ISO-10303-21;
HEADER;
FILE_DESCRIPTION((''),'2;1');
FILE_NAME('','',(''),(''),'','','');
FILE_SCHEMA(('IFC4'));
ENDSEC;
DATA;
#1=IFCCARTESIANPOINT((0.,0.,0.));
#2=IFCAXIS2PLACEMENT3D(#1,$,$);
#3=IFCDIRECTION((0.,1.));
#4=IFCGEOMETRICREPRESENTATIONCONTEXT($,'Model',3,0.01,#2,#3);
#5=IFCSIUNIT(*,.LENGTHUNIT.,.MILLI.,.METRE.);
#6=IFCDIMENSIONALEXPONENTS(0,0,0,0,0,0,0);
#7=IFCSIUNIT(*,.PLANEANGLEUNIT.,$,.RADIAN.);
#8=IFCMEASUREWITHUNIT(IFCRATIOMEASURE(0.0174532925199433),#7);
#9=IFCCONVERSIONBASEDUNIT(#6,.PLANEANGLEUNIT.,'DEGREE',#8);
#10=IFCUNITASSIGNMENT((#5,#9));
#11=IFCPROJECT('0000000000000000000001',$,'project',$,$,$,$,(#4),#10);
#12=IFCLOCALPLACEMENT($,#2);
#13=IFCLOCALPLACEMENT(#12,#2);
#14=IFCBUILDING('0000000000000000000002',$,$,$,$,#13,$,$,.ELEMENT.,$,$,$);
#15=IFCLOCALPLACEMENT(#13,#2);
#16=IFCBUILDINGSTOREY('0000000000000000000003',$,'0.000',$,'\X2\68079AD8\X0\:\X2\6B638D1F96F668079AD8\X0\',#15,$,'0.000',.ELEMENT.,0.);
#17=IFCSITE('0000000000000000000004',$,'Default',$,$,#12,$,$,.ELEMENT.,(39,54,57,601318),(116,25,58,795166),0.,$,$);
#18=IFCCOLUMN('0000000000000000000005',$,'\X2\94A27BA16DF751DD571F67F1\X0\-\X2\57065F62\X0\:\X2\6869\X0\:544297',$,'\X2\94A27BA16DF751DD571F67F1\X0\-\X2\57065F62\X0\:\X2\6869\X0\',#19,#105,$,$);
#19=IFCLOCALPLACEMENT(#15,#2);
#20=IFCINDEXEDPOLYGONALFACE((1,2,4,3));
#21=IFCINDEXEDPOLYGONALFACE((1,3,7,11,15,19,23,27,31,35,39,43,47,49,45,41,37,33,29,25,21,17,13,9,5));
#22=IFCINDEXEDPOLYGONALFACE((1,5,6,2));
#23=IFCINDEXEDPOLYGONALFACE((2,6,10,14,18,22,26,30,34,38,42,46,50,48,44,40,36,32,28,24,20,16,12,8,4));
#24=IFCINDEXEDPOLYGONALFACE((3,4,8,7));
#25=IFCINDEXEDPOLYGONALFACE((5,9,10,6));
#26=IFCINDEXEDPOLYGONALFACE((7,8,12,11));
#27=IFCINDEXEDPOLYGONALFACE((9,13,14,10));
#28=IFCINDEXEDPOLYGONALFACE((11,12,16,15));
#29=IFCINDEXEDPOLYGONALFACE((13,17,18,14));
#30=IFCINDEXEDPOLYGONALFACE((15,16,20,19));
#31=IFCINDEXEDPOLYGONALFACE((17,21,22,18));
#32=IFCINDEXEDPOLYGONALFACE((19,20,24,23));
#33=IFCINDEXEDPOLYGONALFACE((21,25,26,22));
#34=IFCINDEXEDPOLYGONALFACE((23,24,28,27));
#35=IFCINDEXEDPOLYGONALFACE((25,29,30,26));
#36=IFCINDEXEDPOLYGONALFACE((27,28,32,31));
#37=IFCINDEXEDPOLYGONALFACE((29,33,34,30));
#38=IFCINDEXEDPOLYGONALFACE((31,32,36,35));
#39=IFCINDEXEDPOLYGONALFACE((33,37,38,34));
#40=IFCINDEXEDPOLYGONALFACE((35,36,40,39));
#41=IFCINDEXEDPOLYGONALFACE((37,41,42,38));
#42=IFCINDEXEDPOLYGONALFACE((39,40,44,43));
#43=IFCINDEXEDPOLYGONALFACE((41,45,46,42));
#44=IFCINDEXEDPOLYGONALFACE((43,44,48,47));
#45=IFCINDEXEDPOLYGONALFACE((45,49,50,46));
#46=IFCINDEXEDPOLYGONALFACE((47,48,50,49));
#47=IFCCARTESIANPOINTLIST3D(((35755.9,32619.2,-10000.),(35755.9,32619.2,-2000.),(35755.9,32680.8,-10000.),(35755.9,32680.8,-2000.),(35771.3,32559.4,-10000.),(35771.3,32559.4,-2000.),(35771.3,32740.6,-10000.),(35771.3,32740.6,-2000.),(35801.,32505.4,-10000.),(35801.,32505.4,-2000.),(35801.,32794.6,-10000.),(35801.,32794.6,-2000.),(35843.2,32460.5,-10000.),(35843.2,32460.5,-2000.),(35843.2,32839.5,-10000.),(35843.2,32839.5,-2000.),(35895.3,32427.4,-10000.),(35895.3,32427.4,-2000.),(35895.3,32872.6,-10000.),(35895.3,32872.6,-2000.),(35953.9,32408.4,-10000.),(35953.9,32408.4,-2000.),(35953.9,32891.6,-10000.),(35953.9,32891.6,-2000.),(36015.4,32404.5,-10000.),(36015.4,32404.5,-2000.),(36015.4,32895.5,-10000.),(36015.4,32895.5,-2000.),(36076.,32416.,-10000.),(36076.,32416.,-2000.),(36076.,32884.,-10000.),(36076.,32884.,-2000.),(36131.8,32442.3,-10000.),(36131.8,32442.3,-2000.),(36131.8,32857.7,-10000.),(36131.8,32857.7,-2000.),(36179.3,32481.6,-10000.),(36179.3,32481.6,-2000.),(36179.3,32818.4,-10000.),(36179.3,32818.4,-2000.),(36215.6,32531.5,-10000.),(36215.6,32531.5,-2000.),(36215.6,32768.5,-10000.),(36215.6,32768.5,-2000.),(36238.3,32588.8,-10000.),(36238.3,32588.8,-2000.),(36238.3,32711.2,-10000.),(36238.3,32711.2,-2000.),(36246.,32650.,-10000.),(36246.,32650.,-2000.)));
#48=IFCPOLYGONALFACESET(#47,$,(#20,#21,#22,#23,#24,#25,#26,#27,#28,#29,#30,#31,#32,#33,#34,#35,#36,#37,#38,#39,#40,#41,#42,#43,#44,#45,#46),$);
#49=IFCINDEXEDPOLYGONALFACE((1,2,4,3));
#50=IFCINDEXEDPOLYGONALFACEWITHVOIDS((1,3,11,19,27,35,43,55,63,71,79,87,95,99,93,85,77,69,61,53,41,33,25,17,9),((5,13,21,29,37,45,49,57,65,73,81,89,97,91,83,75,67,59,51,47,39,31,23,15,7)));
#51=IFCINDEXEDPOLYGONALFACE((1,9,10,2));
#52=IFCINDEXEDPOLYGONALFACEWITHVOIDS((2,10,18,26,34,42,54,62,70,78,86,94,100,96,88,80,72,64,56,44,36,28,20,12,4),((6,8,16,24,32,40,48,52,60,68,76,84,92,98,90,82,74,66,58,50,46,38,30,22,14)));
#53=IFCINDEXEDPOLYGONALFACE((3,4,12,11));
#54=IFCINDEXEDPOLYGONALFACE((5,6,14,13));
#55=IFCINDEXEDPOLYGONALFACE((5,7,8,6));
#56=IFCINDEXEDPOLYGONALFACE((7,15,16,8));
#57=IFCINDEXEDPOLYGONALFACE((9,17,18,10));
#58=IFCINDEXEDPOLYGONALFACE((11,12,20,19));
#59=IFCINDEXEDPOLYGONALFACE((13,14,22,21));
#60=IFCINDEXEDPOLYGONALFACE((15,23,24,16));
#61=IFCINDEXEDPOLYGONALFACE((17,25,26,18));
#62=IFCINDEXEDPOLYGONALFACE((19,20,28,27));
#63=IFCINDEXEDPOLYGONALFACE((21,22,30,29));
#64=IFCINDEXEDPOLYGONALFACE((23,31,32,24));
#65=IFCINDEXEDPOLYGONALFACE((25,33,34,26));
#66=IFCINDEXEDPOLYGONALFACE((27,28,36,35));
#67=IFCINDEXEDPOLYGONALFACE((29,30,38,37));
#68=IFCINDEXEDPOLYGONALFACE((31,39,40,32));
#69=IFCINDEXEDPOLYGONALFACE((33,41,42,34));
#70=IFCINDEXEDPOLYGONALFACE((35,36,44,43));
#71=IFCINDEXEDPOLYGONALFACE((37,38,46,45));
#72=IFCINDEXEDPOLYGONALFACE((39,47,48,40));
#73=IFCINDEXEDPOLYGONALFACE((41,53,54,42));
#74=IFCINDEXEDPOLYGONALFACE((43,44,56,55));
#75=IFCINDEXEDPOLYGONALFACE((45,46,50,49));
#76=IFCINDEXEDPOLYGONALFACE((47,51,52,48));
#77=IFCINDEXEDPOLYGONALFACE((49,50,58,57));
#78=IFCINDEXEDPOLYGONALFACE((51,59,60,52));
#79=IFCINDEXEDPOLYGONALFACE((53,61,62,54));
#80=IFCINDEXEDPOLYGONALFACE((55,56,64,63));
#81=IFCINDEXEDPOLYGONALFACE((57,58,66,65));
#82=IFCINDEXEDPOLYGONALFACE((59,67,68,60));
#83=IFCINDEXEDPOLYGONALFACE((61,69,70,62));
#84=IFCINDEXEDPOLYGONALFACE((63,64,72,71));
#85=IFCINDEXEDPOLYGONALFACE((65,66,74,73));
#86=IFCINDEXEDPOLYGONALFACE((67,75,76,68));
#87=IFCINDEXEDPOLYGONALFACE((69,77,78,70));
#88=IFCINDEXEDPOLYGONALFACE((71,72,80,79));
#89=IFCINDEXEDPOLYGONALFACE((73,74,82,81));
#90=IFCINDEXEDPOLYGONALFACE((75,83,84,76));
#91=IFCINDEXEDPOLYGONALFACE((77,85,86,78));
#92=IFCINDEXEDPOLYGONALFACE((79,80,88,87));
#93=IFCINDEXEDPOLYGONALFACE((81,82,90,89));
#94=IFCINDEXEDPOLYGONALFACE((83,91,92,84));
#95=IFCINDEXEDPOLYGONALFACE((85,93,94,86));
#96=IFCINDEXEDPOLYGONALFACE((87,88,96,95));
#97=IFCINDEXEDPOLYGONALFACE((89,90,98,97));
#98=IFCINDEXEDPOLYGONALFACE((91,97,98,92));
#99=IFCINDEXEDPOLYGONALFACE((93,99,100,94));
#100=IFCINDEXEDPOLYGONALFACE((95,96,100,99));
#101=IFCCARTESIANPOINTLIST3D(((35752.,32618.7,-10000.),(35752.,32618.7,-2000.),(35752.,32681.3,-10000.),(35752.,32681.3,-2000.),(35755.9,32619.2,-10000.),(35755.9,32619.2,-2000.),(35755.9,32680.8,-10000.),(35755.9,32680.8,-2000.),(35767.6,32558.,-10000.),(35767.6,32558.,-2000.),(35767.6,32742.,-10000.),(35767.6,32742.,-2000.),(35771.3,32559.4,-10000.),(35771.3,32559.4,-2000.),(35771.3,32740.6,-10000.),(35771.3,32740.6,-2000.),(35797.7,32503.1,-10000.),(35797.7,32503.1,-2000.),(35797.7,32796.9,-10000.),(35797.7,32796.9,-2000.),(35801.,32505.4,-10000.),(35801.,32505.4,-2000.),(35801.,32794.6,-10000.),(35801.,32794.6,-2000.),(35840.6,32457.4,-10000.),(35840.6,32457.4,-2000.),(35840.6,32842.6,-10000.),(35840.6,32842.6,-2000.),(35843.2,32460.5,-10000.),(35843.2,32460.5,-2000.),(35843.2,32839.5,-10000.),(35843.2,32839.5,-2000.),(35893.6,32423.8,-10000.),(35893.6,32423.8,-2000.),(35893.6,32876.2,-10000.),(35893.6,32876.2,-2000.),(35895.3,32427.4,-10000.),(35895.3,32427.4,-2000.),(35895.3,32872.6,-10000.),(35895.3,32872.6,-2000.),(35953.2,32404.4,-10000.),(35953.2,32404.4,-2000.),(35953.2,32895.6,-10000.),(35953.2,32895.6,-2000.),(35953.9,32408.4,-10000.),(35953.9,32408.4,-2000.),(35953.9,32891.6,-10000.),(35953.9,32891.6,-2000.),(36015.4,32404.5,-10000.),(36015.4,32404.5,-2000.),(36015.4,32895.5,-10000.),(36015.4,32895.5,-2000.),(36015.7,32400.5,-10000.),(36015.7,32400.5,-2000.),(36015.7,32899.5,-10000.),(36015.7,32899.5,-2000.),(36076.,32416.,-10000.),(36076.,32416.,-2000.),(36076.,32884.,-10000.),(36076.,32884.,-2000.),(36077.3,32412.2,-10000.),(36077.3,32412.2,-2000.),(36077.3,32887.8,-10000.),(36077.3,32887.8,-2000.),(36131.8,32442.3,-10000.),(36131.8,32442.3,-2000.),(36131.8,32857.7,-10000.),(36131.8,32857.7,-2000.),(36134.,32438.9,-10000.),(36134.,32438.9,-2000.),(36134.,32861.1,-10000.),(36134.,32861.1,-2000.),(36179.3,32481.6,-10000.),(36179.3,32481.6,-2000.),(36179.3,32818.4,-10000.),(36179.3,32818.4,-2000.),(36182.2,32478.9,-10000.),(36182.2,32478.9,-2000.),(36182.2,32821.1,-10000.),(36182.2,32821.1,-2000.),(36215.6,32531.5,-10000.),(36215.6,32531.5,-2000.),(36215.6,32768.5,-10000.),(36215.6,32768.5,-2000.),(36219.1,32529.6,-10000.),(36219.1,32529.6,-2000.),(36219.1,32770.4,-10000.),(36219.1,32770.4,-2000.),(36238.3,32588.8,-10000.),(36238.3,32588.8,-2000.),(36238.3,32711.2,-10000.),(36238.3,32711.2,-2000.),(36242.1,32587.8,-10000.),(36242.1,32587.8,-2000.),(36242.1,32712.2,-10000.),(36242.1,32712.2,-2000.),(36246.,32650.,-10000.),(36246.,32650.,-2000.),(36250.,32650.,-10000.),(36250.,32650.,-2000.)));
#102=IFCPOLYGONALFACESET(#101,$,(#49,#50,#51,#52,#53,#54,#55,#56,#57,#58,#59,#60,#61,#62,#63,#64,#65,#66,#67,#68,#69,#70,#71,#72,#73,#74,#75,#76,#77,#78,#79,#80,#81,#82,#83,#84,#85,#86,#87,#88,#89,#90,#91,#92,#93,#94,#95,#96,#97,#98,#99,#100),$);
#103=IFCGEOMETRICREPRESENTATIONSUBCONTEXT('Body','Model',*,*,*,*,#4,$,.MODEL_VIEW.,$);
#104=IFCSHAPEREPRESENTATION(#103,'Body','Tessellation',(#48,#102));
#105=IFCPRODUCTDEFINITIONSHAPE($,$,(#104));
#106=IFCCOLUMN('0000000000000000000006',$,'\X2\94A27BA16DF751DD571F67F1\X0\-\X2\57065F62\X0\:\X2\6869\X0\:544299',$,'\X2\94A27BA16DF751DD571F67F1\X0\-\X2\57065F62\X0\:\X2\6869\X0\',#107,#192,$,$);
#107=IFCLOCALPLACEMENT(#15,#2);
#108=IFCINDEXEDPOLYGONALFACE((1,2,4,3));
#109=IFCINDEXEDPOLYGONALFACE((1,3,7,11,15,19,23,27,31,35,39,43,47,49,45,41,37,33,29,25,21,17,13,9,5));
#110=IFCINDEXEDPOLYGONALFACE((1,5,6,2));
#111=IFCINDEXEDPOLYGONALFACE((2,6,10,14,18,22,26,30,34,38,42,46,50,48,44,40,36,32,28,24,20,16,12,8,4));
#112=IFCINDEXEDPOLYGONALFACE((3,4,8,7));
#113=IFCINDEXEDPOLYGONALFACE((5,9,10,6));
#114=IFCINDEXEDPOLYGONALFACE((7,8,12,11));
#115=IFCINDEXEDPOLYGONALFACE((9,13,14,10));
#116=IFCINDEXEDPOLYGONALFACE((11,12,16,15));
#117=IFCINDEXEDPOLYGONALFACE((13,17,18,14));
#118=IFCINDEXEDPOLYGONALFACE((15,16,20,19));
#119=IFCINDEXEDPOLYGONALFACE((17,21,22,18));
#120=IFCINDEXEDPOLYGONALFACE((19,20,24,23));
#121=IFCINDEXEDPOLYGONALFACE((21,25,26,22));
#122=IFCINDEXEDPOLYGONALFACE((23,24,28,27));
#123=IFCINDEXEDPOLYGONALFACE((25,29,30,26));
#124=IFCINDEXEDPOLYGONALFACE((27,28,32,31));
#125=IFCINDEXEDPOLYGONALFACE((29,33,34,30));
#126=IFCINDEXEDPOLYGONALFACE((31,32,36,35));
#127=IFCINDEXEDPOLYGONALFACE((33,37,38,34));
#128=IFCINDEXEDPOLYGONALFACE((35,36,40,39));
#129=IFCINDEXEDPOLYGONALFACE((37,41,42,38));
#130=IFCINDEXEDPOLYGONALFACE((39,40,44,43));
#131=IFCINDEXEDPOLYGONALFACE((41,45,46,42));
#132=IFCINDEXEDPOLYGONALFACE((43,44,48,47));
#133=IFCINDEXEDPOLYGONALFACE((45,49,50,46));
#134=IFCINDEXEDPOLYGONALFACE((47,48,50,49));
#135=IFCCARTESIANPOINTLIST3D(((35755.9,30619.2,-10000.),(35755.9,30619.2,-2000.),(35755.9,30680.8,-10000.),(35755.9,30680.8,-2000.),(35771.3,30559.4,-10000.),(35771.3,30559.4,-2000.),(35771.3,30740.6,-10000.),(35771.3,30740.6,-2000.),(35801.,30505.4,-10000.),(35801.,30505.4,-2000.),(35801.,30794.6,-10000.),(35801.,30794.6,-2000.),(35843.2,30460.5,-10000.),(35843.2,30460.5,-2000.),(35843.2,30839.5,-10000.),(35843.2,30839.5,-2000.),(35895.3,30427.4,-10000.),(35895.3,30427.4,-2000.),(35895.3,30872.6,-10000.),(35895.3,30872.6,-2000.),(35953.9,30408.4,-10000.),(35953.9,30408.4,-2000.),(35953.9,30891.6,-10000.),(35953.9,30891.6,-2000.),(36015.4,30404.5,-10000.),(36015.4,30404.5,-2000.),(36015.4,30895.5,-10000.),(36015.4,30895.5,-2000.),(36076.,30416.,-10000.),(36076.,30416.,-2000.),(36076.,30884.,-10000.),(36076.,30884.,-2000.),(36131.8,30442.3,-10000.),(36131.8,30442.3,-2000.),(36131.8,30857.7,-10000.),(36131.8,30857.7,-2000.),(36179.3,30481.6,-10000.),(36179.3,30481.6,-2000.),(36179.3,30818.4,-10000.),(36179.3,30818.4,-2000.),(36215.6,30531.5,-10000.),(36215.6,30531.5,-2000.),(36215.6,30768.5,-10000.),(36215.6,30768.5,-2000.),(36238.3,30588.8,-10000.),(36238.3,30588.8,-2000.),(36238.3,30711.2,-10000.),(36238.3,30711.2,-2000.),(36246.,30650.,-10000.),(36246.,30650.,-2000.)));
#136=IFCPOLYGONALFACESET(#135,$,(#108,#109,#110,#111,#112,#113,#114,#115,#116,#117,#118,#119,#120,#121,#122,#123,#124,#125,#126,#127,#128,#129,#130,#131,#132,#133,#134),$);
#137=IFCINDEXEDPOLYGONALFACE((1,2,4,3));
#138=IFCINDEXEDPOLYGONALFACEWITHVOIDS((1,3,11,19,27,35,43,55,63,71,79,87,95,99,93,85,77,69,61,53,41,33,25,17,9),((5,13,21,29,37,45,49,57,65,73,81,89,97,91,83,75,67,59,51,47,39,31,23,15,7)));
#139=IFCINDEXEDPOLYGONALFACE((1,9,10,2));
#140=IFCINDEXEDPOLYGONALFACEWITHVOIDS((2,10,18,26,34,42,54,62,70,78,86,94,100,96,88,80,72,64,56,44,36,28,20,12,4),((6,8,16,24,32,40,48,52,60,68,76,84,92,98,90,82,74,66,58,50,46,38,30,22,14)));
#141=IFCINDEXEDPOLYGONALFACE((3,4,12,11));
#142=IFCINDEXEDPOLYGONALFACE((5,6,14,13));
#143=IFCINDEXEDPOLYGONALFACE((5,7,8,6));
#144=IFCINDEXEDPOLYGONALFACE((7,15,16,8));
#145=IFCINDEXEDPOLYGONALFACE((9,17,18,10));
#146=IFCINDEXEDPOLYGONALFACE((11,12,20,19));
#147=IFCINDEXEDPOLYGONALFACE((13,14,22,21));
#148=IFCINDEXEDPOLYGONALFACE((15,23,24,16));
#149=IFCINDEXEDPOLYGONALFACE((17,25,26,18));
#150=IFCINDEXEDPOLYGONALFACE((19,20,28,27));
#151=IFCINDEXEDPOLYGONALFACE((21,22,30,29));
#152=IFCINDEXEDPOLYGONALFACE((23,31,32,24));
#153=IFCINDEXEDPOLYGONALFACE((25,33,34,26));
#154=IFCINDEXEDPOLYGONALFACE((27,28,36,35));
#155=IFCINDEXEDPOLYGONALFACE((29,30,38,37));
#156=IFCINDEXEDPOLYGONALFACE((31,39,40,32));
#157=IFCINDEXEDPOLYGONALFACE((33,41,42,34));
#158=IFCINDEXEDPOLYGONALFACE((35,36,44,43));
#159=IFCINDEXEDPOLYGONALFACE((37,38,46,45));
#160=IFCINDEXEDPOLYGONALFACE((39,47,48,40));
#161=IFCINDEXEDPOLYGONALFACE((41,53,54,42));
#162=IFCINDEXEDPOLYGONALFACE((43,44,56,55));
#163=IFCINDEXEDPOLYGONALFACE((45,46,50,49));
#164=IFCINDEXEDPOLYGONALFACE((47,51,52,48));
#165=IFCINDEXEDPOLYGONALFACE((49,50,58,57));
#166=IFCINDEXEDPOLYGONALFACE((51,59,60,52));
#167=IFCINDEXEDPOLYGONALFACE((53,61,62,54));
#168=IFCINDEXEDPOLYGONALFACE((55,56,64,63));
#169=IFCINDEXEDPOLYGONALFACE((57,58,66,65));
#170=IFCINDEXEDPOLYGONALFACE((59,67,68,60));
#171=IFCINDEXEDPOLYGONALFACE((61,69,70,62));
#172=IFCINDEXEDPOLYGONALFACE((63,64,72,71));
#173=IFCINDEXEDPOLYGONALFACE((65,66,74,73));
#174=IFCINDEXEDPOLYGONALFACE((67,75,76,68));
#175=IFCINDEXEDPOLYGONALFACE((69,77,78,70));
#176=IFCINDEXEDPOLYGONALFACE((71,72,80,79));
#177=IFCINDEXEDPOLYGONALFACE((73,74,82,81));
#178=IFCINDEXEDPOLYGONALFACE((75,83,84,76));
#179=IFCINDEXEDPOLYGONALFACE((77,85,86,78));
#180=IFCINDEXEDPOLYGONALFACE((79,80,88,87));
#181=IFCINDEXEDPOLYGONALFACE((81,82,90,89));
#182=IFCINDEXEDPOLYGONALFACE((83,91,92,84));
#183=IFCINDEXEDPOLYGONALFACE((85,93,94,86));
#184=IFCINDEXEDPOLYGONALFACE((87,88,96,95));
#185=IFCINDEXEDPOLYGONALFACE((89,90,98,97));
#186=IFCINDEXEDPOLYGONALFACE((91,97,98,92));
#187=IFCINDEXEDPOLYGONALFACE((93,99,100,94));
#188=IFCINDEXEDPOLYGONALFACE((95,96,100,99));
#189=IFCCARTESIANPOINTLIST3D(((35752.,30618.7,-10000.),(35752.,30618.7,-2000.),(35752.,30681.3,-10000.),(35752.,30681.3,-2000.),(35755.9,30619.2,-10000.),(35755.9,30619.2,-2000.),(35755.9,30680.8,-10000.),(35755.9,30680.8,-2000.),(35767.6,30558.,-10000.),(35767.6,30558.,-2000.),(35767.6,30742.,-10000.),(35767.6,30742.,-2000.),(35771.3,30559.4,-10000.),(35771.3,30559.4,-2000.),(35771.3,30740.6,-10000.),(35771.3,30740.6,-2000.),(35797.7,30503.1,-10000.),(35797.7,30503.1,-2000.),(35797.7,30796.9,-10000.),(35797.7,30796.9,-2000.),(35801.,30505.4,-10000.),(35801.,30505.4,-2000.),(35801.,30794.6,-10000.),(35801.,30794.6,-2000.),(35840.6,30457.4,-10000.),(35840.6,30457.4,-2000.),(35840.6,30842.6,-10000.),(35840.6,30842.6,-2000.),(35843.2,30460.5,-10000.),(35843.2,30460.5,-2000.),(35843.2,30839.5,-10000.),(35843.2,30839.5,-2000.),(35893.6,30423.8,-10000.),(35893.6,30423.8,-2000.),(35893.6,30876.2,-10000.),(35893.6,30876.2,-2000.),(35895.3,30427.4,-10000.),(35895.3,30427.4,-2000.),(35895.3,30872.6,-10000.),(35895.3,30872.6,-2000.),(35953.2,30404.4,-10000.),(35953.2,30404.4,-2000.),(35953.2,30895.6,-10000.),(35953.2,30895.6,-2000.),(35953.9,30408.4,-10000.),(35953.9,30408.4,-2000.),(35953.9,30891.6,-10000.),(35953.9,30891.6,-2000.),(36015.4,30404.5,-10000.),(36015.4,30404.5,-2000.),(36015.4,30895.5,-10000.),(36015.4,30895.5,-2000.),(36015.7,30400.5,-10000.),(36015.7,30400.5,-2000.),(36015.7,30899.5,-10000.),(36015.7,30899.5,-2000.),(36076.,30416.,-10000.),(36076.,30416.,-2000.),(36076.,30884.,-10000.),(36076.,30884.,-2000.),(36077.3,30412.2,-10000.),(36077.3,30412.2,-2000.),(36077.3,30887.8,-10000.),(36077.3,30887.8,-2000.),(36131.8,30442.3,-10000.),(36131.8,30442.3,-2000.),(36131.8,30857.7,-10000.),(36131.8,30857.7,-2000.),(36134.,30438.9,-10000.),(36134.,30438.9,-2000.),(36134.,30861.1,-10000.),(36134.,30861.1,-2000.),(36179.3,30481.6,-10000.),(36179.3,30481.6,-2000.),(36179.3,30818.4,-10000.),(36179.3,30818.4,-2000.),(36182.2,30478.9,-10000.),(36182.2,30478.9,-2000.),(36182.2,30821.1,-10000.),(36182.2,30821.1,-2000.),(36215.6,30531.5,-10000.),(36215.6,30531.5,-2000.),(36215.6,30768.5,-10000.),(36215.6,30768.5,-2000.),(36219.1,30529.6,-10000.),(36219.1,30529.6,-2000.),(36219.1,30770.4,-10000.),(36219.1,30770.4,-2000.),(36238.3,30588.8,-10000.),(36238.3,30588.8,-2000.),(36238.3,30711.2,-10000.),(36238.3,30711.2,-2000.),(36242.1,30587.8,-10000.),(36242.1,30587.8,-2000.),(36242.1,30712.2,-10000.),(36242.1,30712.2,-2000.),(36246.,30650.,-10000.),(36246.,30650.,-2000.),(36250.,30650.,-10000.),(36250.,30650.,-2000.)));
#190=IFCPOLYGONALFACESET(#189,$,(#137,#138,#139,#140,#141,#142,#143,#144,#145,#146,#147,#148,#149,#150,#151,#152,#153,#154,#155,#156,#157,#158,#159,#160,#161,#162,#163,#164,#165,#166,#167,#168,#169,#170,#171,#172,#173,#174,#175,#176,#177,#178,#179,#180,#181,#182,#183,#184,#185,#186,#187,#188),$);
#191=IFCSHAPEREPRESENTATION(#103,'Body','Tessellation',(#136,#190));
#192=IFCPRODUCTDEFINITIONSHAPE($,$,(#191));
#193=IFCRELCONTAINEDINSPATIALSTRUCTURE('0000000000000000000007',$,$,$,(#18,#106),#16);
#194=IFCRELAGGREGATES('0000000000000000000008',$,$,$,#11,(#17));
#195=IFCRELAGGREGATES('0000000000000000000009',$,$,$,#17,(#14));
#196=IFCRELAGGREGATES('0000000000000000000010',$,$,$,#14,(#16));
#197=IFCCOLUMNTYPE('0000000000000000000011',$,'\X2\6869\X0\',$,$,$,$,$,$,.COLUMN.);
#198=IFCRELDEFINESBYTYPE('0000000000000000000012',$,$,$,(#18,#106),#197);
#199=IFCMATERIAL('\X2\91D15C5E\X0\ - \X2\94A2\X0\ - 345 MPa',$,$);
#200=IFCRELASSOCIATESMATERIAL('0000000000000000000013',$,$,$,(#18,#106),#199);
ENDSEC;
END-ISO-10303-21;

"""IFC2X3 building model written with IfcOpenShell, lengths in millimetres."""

from ifc_helpers import new_model, entity, si_unit, converted_unit, direction, frame, frame_2d, origin, place, context, subcontext, project, spatial, circle, hollow_circle, extrude, source, transform, mapped, material, type_object, type_shapes, element, save


model = new_model("IFC2X3")

# Units and contexts
model_context = context("Model", 3, precision=0.01, world=origin(), true_north=direction((0.0, 1.0)))
body_context = subcontext(model_context, "Body", "Model", "MODEL_VIEW")
ifc_project = project(units=[si_unit("LENGTHUNIT", "METRE", prefix="MILLI"), converted_unit("PLANEANGLEUNIT", "DEGREE", entity("IfcRatioMeasure", 0.0174532925199433), si_unit("PLANEANGLEUNIT", "RADIAN"), dimensions=[0, 0, 0, 0, 0, 0, 0])], contexts=[model_context])

# Site, building, storey
site_placement = place(None, origin())
site = spatial("IfcSite", under=ifc_project, at=site_placement, Name="Default", CompositionType="ELEMENT", RefLatitude=(39, 54, 57, 601318), RefLongitude=(116, 25, 58, 795166), RefElevation=0.0)
building_placement = place(site_placement, origin())
building = spatial("IfcBuilding", under=site, at=building_placement, CompositionType="ELEMENT")
storey_placement = place(building_placement, origin())
storey = spatial("IfcBuildingStorey", under=building, at=storey_placement, Name="0.000", ObjectType="标高:正负零标高", LongName="0.000", CompositionType="ELEMENT", Elevation=0.0)

# Columns
ifc_material_1 = material(Name="金属 - 钢 - 345 MPa")
column_type_1 = type_object("IfcColumnType", Name="桩", PredefinedType="COLUMN")
shared_shape_1 = source(origin(), body_context, "Body", "SweptSolid", [
    extrude(circle(Radius=246.0, at=frame_2d((0.0, 0.0), x_axis=(1.0, 0.0))), frame((0.0, 0.0, -10000.0)), (0.0, 0.0, 1.0), 8000.0),
    extrude(hollow_circle(Radius=250.0, WallThickness=4.0, at=frame_2d((0.0, 0.0), x_axis=(1.0, 0.0))), frame((0.0, 0.0, -10000.0)), (0.0, 0.0, 1.0), 8000.0),
])
type_shapes(column_type_1, [shared_shape_1])
for number, where, name in (
    (1, (36000.0, 32650.0, 0.0), "钢管混凝土柱-圆形:桩:544297"),
    (2, (36000.0, 30650.0, 0.0), "钢管混凝土柱-圆形:桩:544299"),
):
    element("IfcColumn", number, at=place(storey_placement, frame(where)), inside=storey, type_object=column_type_1, material=ifc_material_1, Name=name, ObjectType="钢管混凝土柱-圆形:桩", context=body_context, shape_type="MappedRepresentation", body=[
        mapped(shared_shape_1, transform((0.0, 0.0, 0.0), scale=1.0)),
    ])

save(model, "model.ifc")
